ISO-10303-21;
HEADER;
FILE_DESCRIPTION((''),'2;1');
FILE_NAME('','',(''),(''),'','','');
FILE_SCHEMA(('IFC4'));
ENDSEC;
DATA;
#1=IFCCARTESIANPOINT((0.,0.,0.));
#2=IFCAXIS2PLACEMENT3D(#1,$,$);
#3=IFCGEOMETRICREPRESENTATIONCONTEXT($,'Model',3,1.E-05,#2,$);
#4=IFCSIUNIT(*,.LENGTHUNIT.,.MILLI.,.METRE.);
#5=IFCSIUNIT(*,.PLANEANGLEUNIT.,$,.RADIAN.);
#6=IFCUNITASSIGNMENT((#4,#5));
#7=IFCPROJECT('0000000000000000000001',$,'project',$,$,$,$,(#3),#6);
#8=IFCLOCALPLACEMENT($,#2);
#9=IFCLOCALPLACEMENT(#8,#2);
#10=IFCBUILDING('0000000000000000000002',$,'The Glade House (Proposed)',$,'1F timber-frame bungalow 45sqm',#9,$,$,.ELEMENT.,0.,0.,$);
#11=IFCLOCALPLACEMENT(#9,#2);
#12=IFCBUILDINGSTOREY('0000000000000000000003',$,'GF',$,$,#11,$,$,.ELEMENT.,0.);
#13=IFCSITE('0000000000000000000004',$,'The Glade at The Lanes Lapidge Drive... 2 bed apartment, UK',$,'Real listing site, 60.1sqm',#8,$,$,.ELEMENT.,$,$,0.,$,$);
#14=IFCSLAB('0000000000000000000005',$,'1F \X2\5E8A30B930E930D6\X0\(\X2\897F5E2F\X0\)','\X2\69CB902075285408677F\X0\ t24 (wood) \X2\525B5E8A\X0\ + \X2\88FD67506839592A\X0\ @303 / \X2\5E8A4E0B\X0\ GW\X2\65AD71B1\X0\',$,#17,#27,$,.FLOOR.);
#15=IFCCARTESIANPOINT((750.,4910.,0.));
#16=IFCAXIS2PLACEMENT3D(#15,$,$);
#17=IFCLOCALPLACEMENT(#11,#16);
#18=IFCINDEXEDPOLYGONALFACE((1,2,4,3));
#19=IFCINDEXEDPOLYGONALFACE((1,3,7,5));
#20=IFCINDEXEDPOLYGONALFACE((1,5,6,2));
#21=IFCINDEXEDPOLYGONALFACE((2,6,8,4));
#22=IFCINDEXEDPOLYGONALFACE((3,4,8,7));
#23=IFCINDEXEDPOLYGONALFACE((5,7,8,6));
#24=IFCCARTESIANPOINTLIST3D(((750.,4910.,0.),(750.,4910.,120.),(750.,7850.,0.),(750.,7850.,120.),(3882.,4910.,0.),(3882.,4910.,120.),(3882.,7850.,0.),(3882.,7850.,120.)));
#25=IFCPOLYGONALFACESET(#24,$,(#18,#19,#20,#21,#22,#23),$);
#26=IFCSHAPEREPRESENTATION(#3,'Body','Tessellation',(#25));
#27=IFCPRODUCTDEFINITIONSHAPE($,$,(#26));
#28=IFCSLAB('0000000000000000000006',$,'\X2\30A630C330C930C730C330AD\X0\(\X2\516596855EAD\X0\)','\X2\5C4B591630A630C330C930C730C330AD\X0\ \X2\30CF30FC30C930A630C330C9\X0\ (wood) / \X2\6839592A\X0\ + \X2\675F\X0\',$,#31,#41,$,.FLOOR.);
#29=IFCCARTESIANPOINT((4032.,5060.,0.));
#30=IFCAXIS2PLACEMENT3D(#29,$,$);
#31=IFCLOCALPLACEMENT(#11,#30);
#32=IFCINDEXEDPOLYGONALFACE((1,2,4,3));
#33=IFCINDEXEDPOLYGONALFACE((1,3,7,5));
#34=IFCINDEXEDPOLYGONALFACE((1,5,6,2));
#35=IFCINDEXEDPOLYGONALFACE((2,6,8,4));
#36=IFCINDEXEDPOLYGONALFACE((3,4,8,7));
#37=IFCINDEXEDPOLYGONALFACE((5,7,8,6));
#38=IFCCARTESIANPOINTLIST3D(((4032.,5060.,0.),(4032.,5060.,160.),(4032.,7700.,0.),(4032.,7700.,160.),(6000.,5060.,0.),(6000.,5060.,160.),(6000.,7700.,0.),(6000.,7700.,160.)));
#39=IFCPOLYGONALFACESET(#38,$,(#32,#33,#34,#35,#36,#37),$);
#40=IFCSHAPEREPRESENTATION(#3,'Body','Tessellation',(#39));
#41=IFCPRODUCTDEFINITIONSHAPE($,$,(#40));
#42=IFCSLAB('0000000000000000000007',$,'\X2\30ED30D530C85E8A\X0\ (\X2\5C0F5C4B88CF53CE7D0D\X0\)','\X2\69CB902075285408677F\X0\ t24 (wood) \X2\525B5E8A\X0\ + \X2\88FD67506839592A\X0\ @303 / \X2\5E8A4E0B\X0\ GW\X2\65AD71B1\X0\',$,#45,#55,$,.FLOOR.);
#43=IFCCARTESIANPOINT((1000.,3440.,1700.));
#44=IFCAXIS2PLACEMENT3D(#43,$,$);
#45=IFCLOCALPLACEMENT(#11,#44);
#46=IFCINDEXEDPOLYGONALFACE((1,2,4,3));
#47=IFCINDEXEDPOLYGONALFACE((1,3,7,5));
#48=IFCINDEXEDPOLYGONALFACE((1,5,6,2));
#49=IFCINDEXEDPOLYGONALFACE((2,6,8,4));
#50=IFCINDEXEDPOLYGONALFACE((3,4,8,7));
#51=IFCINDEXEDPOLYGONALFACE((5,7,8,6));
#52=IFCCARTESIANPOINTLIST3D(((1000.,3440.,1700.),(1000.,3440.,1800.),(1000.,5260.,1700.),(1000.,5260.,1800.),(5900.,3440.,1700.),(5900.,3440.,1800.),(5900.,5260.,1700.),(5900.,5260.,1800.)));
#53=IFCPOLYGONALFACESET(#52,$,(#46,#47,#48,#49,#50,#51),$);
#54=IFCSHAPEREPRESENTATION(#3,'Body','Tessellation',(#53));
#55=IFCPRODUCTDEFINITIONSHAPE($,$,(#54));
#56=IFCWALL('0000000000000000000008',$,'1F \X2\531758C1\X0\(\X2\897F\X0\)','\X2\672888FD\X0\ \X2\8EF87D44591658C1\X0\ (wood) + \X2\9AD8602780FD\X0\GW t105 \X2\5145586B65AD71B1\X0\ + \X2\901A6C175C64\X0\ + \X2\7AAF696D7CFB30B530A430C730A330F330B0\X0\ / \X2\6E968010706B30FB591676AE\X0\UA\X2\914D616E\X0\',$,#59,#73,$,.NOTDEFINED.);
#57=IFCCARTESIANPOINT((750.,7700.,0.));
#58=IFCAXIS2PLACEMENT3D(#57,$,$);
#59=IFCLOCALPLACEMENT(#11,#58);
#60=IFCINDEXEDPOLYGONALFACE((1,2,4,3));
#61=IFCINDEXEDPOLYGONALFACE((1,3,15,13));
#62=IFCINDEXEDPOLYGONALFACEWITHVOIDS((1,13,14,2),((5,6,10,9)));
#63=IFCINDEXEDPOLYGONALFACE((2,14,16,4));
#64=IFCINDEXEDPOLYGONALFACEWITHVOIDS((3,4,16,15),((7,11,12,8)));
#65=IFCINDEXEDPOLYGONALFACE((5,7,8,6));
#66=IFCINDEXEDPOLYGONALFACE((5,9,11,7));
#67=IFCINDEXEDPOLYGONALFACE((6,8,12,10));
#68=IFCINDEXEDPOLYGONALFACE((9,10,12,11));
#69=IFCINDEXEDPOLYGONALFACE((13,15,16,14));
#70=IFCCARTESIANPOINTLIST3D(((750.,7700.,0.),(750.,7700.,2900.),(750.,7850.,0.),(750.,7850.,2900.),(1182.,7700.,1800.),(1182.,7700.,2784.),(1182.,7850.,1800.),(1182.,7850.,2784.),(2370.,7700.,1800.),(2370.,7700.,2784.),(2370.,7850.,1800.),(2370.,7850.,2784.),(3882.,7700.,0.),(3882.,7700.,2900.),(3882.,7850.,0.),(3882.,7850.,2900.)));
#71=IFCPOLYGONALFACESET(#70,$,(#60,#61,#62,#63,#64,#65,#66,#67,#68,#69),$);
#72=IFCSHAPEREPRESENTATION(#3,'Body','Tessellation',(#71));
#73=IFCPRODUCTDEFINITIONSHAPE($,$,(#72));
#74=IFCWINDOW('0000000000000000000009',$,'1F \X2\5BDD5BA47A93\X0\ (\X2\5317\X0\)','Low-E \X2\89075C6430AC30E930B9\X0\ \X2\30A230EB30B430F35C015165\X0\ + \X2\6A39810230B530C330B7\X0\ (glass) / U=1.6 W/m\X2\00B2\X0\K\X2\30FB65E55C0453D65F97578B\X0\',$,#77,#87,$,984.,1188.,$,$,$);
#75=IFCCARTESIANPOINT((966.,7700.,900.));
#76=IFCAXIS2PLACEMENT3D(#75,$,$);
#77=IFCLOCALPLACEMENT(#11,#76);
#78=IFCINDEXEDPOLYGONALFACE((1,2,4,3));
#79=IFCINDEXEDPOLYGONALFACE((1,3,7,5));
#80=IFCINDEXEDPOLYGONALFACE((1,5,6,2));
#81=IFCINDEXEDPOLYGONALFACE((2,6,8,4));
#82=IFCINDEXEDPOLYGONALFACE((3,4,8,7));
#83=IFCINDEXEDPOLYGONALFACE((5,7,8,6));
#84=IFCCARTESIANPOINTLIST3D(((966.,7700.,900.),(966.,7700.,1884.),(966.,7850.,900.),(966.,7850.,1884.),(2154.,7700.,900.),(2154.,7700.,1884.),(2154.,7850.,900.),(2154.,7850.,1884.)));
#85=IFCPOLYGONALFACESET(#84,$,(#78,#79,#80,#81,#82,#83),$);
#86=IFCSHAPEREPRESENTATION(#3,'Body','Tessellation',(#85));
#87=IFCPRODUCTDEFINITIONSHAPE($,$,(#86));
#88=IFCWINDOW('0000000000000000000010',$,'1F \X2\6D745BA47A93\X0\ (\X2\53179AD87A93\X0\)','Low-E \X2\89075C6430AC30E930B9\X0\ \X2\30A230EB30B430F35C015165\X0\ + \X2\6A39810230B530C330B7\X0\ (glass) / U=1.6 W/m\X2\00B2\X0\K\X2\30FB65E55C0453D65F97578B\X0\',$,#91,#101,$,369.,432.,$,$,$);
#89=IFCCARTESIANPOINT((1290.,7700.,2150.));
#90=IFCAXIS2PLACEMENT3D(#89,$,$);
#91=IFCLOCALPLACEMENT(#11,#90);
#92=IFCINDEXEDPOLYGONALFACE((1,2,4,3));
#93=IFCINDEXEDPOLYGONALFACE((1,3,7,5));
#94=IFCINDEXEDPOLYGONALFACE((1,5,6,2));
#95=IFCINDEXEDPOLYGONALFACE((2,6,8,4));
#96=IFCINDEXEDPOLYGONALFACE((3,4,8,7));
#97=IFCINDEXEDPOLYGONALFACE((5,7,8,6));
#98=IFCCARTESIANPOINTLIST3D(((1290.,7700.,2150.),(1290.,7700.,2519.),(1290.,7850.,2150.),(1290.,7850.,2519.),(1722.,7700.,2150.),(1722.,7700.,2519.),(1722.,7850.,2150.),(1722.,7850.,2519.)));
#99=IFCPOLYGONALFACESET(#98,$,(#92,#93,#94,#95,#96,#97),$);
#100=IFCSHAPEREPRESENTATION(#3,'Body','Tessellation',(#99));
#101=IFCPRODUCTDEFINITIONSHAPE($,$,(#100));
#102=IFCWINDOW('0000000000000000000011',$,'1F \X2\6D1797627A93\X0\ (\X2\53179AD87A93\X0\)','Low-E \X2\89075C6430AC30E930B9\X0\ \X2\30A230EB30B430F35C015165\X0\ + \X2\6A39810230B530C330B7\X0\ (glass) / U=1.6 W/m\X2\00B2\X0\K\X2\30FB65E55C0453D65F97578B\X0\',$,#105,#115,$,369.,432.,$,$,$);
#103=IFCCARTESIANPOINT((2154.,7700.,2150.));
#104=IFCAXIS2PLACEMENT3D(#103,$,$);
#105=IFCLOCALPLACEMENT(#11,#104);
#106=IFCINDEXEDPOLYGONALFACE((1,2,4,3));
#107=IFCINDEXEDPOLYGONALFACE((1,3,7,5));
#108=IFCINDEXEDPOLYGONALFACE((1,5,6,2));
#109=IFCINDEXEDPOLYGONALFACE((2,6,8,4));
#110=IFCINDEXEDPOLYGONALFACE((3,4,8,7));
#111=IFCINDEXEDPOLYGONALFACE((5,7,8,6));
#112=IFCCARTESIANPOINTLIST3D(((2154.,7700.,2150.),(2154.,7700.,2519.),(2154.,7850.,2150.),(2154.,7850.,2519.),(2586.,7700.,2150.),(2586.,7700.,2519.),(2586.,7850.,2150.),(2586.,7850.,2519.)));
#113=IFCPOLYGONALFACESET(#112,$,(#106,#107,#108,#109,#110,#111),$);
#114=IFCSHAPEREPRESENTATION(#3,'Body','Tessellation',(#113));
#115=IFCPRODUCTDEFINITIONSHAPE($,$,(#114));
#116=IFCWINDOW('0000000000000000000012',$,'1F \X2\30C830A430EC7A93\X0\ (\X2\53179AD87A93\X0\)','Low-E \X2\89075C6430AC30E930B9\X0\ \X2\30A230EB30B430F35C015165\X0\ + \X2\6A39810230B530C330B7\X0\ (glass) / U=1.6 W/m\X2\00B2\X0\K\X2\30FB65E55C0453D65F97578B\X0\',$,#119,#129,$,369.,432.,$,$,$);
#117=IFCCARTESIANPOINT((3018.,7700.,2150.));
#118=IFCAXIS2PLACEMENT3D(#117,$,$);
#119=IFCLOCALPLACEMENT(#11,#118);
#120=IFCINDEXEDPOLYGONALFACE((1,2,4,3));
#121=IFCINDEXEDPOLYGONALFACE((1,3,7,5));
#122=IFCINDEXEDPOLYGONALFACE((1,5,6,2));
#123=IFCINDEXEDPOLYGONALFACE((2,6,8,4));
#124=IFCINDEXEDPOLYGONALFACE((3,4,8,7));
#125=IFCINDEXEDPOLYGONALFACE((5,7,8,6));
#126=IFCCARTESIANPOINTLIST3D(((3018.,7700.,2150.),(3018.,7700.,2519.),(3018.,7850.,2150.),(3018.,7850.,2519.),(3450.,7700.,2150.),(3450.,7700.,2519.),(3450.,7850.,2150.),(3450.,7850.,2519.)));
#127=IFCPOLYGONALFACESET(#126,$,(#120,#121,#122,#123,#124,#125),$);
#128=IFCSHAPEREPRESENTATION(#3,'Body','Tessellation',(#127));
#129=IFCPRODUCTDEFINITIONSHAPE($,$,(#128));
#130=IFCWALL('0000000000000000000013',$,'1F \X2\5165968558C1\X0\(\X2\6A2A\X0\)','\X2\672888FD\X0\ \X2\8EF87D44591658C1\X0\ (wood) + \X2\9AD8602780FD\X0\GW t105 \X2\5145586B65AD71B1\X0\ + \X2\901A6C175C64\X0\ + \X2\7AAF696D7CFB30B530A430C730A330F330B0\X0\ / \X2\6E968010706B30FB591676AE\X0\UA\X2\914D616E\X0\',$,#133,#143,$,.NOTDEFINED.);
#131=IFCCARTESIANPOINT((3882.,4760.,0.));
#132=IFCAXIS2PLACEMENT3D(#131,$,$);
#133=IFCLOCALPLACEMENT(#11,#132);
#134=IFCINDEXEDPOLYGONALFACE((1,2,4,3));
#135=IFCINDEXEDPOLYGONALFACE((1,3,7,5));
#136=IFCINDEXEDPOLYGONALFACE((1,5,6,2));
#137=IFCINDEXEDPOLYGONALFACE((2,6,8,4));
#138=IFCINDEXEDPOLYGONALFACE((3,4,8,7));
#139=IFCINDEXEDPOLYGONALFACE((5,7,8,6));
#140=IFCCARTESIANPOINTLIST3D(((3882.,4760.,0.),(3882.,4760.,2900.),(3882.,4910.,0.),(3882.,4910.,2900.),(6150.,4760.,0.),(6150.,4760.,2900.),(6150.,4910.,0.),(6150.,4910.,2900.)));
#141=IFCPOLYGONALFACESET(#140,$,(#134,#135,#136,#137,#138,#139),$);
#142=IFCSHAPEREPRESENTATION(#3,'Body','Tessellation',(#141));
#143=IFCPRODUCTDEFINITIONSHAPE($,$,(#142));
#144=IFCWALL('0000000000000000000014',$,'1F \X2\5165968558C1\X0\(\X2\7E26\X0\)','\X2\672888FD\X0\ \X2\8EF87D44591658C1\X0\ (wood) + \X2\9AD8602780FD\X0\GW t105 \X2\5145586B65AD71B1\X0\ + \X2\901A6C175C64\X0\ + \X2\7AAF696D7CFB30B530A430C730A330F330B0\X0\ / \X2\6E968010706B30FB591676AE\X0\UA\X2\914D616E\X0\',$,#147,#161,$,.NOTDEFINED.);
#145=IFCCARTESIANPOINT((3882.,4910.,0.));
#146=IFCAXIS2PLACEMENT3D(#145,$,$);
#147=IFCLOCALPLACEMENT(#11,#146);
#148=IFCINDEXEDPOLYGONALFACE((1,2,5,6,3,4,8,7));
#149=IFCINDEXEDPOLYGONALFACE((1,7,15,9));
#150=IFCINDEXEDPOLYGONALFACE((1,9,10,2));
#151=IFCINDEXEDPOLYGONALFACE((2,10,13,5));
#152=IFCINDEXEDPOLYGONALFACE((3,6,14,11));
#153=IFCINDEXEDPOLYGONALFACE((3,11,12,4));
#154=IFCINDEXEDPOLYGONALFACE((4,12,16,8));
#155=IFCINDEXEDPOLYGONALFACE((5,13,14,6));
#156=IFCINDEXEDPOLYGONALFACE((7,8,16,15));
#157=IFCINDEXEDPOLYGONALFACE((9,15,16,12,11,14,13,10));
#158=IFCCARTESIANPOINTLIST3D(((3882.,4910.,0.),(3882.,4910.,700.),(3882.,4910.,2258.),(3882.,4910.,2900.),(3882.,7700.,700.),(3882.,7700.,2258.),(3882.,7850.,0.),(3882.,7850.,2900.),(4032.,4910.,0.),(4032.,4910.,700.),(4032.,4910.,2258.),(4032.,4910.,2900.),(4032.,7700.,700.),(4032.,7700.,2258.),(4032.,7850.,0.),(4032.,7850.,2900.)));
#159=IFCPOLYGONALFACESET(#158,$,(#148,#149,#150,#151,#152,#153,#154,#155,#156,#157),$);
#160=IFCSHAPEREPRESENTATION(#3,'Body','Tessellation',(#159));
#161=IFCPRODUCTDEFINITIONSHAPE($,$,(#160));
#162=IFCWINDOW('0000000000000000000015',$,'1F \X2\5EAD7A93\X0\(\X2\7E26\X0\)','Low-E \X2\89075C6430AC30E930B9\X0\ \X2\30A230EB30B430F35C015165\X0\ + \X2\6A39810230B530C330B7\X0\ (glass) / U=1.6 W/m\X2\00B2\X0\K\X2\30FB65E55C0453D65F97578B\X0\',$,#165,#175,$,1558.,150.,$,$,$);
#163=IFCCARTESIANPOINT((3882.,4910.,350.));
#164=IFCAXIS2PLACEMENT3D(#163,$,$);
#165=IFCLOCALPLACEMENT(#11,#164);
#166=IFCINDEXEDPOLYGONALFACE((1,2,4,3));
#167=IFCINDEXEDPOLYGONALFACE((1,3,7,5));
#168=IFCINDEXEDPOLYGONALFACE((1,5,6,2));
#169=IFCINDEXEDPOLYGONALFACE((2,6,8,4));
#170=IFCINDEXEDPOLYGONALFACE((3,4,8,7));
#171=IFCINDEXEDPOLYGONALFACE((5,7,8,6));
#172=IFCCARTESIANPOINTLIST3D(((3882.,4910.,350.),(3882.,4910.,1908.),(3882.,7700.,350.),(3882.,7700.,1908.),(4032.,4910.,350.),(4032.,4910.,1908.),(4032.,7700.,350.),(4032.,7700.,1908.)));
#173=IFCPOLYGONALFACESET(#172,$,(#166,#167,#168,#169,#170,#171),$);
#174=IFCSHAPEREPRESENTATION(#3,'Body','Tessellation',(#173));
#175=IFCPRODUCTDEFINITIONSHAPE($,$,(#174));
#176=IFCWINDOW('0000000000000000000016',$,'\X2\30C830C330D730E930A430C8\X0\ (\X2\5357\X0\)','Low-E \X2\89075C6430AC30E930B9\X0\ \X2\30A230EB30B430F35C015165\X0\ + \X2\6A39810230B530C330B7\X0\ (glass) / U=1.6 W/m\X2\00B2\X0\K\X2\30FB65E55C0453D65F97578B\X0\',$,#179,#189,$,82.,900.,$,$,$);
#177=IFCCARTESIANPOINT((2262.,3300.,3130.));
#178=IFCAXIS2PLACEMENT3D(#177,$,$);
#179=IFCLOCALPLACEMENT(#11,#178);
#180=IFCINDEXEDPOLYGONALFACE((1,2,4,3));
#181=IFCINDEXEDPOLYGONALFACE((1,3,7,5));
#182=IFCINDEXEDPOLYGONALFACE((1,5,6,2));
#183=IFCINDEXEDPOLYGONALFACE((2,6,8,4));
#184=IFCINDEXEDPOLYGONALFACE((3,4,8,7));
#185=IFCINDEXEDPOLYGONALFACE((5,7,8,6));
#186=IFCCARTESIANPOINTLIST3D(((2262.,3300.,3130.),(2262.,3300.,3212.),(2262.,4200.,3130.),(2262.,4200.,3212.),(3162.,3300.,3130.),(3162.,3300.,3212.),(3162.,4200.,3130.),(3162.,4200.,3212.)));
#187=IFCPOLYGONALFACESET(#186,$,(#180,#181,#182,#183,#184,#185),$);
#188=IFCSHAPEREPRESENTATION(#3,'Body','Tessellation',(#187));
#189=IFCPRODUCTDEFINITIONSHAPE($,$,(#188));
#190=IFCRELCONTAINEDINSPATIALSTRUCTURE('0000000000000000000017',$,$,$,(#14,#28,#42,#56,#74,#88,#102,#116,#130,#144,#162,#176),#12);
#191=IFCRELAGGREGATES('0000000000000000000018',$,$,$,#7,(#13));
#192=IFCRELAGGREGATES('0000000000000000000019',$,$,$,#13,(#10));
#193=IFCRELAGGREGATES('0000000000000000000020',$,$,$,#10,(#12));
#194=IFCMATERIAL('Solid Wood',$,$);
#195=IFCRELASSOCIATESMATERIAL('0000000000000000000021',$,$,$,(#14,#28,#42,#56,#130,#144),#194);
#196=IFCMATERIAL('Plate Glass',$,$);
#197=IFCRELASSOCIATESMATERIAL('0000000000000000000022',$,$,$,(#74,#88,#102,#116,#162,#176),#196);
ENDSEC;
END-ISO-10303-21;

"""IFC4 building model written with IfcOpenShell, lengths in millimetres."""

from ifc_helpers import new_model, si_unit, frame, frame_2d, origin, place, context, project, spatial, rectangle, extrude, material, element, fill, save


model = new_model("IFC4")

# Units and contexts
model_context = context("Model", 3, precision=1e-05, world=origin())
ifc_project = project(units=[si_unit("LENGTHUNIT", "METRE", prefix="MILLI"), si_unit("PLANEANGLEUNIT", "RADIAN")], contexts=[model_context])

# Site, building, storey
site_placement = place(None, origin())
site = spatial("IfcSite", under=ifc_project, at=site_placement, Name="The Glade at The Lanes Lapidge Drive... 2 bed apartment, UK", ObjectType="Real listing site, 60.1sqm", CompositionType="ELEMENT", RefElevation=0.0)
building_placement = place(site_placement, origin())
building = spatial("IfcBuilding", under=site, at=building_placement, Name="The Glade House (Proposed)", ObjectType="1F timber-frame bungalow 45sqm", CompositionType="ELEMENT", ElevationOfRefHeight=0.0, ElevationOfTerrain=0.0)
storey_placement = place(building_placement, origin())
storey = spatial("IfcBuildingStorey", under=building, at=storey_placement, Name="GF", CompositionType="ELEMENT", Elevation=0.0)

# Slabs
ifc_material_1 = material(Name="Solid Wood")
slab_1_placement = place(storey_placement, frame((750.0, 4910.0, 0.0)))
element("IfcSlab", 1, at=slab_1_placement, inside=storey, material=ifc_material_1, Name="1F 床スラブ(西帯)", Description="構造用合板 t24 (wood) 剛床 + 製材根太 @303 / 床下 GW断熱", PredefinedType="FLOOR", context=model_context, shape_type="SweptSolid", body=[
    extrude(rectangle(XDim=3132.0, YDim=2940.0, at=frame_2d((1566.0, 1470.0))), frame((750.0, 4910.0, 0.0)), (0.0, 0.0, 1.0), 120.0),
])
slab_2_placement = place(storey_placement, frame((4032.0, 5060.0, 0.0)))
element("IfcSlab", 2, at=slab_2_placement, inside=storey, material=ifc_material_1, Name="ウッドデッキ(入隅庭)", Description="屋外ウッドデッキ ハードウッド (wood) / 根太 + 束", PredefinedType="FLOOR", context=model_context, shape_type="SweptSolid", body=[
    extrude(rectangle(XDim=1968.0, YDim=2640.0, at=frame_2d((984.0, 1320.0))), frame((4032.0, 5060.0, 0.0)), (0.0, 0.0, 1.0), 160.0),
])
slab_3_placement = place(storey_placement, frame((1000.0, 3440.0, 1700.0)))
element("IfcSlab", 3, at=slab_3_placement, inside=storey, material=ifc_material_1, Name="ロフト床 (小屋裏収納)", Description="構造用合板 t24 (wood) 剛床 + 製材根太 @303 / 床下 GW断熱", PredefinedType="FLOOR", context=model_context, shape_type="SweptSolid", body=[
    extrude(rectangle(XDim=4900.0, YDim=1820.0, at=frame_2d((2450.0, 910.0))), frame((1000.0, 3440.0, 1700.0)), (0.0, 0.0, 1.0), 100.0),
])

# Wall, openings, windows
wall_1_placement = place(storey_placement, frame((750.0, 7700.0, 0.0)))
wall_1 = element("IfcWall", 4, at=wall_1_placement, inside=storey, material=ifc_material_1, Name="1F 北壁(西)", Description="木製 軸組外壁 (wood) + 高性能GW t105 充填断熱 + 通気層 + 窯業系サイディング / 準耐火・外皮UA配慮", PredefinedType="NOTDEFINED", context=model_context, shape_type="SweptSolid", body=[
    extrude(rectangle(XDim=3132.0, YDim=150.0, at=frame_2d((1566.0, 75.0))), frame((750.0, 7700.0, 0.0)), (0.0, 0.0, 1.0), 2900.0),
])
opening_1_placement = place(storey_placement, frame((966.0, 7700.0, 900.0)))
opening_1 = element("IfcOpeningElement", 5, at=opening_1_placement, cuts=wall_1, PredefinedType="NOTDEFINED", context=model_context, shape_type="SweptSolid", body=[
    extrude(rectangle(XDim=1188.0, YDim=150.0, at=frame_2d((594.0, 75.0))), frame((966.0, 7700.0, 900.0)), (0.0, 0.0, 1.0), 984.0),
])
opening_2_placement = place(storey_placement, frame((1290.0, 7700.0, 2150.0)))
opening_2 = element("IfcOpeningElement", 6, at=opening_2_placement, cuts=wall_1, PredefinedType="NOTDEFINED", context=model_context, shape_type="SweptSolid", body=[
    extrude(rectangle(XDim=432.0, YDim=150.0, at=frame_2d((216.0, 75.0))), frame((1290.0, 7700.0, 2150.0)), (0.0, 0.0, 1.0), 369.0),
])
opening_3_placement = place(storey_placement, frame((2154.0, 7700.0, 2150.0)))
opening_3 = element("IfcOpeningElement", 7, at=opening_3_placement, cuts=wall_1, PredefinedType="NOTDEFINED", context=model_context, shape_type="SweptSolid", body=[
    extrude(rectangle(XDim=432.0, YDim=150.0, at=frame_2d((216.0, 75.0))), frame((2154.0, 7700.0, 2150.0)), (0.0, 0.0, 1.0), 369.0),
])
opening_4_placement = place(storey_placement, frame((3018.0, 7700.0, 2150.0)))
opening_4 = element("IfcOpeningElement", 8, at=opening_4_placement, cuts=wall_1, PredefinedType="NOTDEFINED", context=model_context, shape_type="SweptSolid", body=[
    extrude(rectangle(XDim=432.0, YDim=150.0, at=frame_2d((216.0, 75.0))), frame((3018.0, 7700.0, 2150.0)), (0.0, 0.0, 1.0), 369.0),
])
ifc_material_2 = material(Name="Plate Glass")
window_1_placement = place(storey_placement, frame((966.0, 7700.0, 900.0)))
window_1 = element("IfcWindow", 9, at=window_1_placement, inside=storey, material=ifc_material_2, Name="1F 寝室窓 (北)", Description="Low-E 複層ガラス アルゴン封入 + 樹脂サッシ (glass) / U=1.6 W/m²K・日射取得型", OverallHeight=984.0, OverallWidth=1188.0, context=model_context, shape_type="SweptSolid", body=[
    extrude(rectangle(XDim=1188.0, YDim=150.0, at=frame_2d((594.0, 75.0))), frame((966.0, 7700.0, 900.0)), (0.0, 0.0, 1.0), 984.0),
])
fill(opening_1, window_1)
window_2_placement = place(storey_placement, frame((1290.0, 7700.0, 2150.0)))
window_2 = element("IfcWindow", 10, at=window_2_placement, inside=storey, material=ifc_material_2, Name="1F 浴室窓 (北高窓)", Description="Low-E 複層ガラス アルゴン封入 + 樹脂サッシ (glass) / U=1.6 W/m²K・日射取得型", OverallHeight=369.0, OverallWidth=432.0, context=model_context, shape_type="SweptSolid", body=[
    extrude(rectangle(XDim=432.0, YDim=150.0, at=frame_2d((216.0, 75.0))), frame((1290.0, 7700.0, 2150.0)), (0.0, 0.0, 1.0), 369.0),
])
fill(opening_2, window_2)
window_3_placement = place(storey_placement, frame((2154.0, 7700.0, 2150.0)))
window_3 = element("IfcWindow", 11, at=window_3_placement, inside=storey, material=ifc_material_2, Name="1F 洗面窓 (北高窓)", Description="Low-E 複層ガラス アルゴン封入 + 樹脂サッシ (glass) / U=1.6 W/m²K・日射取得型", OverallHeight=369.0, OverallWidth=432.0, context=model_context, shape_type="SweptSolid", body=[
    extrude(rectangle(XDim=432.0, YDim=150.0, at=frame_2d((216.0, 75.0))), frame((2154.0, 7700.0, 2150.0)), (0.0, 0.0, 1.0), 369.0),
])
fill(opening_3, window_3)
window_4_placement = place(storey_placement, frame((3018.0, 7700.0, 2150.0)))
window_4 = element("IfcWindow", 12, at=window_4_placement, inside=storey, material=ifc_material_2, Name="1F トイレ窓 (北高窓)", Description="Low-E 複層ガラス アルゴン封入 + 樹脂サッシ (glass) / U=1.6 W/m²K・日射取得型", OverallHeight=369.0, OverallWidth=432.0, context=model_context, shape_type="SweptSolid", body=[
    extrude(rectangle(XDim=432.0, YDim=150.0, at=frame_2d((216.0, 75.0))), frame((3018.0, 7700.0, 2150.0)), (0.0, 0.0, 1.0), 369.0),
])
fill(opening_4, window_4)

# Wall
wall_2_placement = place(storey_placement, frame((3882.0, 4760.0, 0.0)))
element("IfcWall", 13, at=wall_2_placement, inside=storey, material=ifc_material_1, Name="1F 入隅壁(横)", Description="木製 軸組外壁 (wood) + 高性能GW t105 充填断熱 + 通気層 + 窯業系サイディング / 準耐火・外皮UA配慮", PredefinedType="NOTDEFINED", context=model_context, shape_type="SweptSolid", body=[
    extrude(rectangle(XDim=2268.0, YDim=150.0, at=frame_2d((1134.0, 75.0))), frame((3882.0, 4760.0, 0.0)), (0.0, 0.0, 1.0), 2900.0),
])

# Wall, opening, window
wall_3_placement = place(storey_placement, frame((3882.0, 4910.0, 0.0)))
wall_3 = element("IfcWall", 14, at=wall_3_placement, inside=storey, material=ifc_material_1, Name="1F 入隅壁(縦)", Description="木製 軸組外壁 (wood) + 高性能GW t105 充填断熱 + 通気層 + 窯業系サイディング / 準耐火・外皮UA配慮", PredefinedType="NOTDEFINED", context=model_context, shape_type="SweptSolid", body=[
    extrude(rectangle(XDim=150.0, YDim=2940.0, at=frame_2d((75.0, 1470.0))), frame((3882.0, 4910.0, 0.0)), (0.0, 0.0, 1.0), 2900.0),
])
opening_5_placement = place(storey_placement, frame((3882.0, 4910.0, 350.0)))
opening_5 = element("IfcOpeningElement", 15, at=opening_5_placement, cuts=wall_3, PredefinedType="NOTDEFINED", context=model_context, shape_type="SweptSolid", body=[
    extrude(rectangle(XDim=150.0, YDim=2790.0, at=frame_2d((75.0, 1395.0))), frame((3882.0, 4910.0, 350.0)), (0.0, 0.0, 1.0), 1558.0),
])
window_5_placement = place(storey_placement, frame((3882.0, 4910.0, 350.0)))
window_5 = element("IfcWindow", 16, at=window_5_placement, inside=storey, material=ifc_material_2, Name="1F 庭窓(縦)", Description="Low-E 複層ガラス アルゴン封入 + 樹脂サッシ (glass) / U=1.6 W/m²K・日射取得型", OverallHeight=1558.0, OverallWidth=150.0, context=model_context, shape_type="SweptSolid", body=[
    extrude(rectangle(XDim=150.0, YDim=2790.0, at=frame_2d((75.0, 1395.0))), frame((3882.0, 4910.0, 350.0)), (0.0, 0.0, 1.0), 1558.0),
])
fill(opening_5, window_5)

# Window
window_6_placement = place(storey_placement, frame((2262.0, 3300.0, 3130.0)))
element("IfcWindow", 17, at=window_6_placement, inside=storey, material=ifc_material_2, Name="トップライト (南)", Description="Low-E 複層ガラス アルゴン封入 + 樹脂サッシ (glass) / U=1.6 W/m²K・日射取得型", OverallHeight=82.0, OverallWidth=900.0, context=model_context, shape_type="SweptSolid", body=[
    extrude(rectangle(XDim=900.0, YDim=900.0, at=frame_2d((450.0, 450.0))), frame((2262.0, 3300.0, 3130.0)), (0.0, 0.0, 1.0), 82.0),
])

save(model, "model.ifc")
